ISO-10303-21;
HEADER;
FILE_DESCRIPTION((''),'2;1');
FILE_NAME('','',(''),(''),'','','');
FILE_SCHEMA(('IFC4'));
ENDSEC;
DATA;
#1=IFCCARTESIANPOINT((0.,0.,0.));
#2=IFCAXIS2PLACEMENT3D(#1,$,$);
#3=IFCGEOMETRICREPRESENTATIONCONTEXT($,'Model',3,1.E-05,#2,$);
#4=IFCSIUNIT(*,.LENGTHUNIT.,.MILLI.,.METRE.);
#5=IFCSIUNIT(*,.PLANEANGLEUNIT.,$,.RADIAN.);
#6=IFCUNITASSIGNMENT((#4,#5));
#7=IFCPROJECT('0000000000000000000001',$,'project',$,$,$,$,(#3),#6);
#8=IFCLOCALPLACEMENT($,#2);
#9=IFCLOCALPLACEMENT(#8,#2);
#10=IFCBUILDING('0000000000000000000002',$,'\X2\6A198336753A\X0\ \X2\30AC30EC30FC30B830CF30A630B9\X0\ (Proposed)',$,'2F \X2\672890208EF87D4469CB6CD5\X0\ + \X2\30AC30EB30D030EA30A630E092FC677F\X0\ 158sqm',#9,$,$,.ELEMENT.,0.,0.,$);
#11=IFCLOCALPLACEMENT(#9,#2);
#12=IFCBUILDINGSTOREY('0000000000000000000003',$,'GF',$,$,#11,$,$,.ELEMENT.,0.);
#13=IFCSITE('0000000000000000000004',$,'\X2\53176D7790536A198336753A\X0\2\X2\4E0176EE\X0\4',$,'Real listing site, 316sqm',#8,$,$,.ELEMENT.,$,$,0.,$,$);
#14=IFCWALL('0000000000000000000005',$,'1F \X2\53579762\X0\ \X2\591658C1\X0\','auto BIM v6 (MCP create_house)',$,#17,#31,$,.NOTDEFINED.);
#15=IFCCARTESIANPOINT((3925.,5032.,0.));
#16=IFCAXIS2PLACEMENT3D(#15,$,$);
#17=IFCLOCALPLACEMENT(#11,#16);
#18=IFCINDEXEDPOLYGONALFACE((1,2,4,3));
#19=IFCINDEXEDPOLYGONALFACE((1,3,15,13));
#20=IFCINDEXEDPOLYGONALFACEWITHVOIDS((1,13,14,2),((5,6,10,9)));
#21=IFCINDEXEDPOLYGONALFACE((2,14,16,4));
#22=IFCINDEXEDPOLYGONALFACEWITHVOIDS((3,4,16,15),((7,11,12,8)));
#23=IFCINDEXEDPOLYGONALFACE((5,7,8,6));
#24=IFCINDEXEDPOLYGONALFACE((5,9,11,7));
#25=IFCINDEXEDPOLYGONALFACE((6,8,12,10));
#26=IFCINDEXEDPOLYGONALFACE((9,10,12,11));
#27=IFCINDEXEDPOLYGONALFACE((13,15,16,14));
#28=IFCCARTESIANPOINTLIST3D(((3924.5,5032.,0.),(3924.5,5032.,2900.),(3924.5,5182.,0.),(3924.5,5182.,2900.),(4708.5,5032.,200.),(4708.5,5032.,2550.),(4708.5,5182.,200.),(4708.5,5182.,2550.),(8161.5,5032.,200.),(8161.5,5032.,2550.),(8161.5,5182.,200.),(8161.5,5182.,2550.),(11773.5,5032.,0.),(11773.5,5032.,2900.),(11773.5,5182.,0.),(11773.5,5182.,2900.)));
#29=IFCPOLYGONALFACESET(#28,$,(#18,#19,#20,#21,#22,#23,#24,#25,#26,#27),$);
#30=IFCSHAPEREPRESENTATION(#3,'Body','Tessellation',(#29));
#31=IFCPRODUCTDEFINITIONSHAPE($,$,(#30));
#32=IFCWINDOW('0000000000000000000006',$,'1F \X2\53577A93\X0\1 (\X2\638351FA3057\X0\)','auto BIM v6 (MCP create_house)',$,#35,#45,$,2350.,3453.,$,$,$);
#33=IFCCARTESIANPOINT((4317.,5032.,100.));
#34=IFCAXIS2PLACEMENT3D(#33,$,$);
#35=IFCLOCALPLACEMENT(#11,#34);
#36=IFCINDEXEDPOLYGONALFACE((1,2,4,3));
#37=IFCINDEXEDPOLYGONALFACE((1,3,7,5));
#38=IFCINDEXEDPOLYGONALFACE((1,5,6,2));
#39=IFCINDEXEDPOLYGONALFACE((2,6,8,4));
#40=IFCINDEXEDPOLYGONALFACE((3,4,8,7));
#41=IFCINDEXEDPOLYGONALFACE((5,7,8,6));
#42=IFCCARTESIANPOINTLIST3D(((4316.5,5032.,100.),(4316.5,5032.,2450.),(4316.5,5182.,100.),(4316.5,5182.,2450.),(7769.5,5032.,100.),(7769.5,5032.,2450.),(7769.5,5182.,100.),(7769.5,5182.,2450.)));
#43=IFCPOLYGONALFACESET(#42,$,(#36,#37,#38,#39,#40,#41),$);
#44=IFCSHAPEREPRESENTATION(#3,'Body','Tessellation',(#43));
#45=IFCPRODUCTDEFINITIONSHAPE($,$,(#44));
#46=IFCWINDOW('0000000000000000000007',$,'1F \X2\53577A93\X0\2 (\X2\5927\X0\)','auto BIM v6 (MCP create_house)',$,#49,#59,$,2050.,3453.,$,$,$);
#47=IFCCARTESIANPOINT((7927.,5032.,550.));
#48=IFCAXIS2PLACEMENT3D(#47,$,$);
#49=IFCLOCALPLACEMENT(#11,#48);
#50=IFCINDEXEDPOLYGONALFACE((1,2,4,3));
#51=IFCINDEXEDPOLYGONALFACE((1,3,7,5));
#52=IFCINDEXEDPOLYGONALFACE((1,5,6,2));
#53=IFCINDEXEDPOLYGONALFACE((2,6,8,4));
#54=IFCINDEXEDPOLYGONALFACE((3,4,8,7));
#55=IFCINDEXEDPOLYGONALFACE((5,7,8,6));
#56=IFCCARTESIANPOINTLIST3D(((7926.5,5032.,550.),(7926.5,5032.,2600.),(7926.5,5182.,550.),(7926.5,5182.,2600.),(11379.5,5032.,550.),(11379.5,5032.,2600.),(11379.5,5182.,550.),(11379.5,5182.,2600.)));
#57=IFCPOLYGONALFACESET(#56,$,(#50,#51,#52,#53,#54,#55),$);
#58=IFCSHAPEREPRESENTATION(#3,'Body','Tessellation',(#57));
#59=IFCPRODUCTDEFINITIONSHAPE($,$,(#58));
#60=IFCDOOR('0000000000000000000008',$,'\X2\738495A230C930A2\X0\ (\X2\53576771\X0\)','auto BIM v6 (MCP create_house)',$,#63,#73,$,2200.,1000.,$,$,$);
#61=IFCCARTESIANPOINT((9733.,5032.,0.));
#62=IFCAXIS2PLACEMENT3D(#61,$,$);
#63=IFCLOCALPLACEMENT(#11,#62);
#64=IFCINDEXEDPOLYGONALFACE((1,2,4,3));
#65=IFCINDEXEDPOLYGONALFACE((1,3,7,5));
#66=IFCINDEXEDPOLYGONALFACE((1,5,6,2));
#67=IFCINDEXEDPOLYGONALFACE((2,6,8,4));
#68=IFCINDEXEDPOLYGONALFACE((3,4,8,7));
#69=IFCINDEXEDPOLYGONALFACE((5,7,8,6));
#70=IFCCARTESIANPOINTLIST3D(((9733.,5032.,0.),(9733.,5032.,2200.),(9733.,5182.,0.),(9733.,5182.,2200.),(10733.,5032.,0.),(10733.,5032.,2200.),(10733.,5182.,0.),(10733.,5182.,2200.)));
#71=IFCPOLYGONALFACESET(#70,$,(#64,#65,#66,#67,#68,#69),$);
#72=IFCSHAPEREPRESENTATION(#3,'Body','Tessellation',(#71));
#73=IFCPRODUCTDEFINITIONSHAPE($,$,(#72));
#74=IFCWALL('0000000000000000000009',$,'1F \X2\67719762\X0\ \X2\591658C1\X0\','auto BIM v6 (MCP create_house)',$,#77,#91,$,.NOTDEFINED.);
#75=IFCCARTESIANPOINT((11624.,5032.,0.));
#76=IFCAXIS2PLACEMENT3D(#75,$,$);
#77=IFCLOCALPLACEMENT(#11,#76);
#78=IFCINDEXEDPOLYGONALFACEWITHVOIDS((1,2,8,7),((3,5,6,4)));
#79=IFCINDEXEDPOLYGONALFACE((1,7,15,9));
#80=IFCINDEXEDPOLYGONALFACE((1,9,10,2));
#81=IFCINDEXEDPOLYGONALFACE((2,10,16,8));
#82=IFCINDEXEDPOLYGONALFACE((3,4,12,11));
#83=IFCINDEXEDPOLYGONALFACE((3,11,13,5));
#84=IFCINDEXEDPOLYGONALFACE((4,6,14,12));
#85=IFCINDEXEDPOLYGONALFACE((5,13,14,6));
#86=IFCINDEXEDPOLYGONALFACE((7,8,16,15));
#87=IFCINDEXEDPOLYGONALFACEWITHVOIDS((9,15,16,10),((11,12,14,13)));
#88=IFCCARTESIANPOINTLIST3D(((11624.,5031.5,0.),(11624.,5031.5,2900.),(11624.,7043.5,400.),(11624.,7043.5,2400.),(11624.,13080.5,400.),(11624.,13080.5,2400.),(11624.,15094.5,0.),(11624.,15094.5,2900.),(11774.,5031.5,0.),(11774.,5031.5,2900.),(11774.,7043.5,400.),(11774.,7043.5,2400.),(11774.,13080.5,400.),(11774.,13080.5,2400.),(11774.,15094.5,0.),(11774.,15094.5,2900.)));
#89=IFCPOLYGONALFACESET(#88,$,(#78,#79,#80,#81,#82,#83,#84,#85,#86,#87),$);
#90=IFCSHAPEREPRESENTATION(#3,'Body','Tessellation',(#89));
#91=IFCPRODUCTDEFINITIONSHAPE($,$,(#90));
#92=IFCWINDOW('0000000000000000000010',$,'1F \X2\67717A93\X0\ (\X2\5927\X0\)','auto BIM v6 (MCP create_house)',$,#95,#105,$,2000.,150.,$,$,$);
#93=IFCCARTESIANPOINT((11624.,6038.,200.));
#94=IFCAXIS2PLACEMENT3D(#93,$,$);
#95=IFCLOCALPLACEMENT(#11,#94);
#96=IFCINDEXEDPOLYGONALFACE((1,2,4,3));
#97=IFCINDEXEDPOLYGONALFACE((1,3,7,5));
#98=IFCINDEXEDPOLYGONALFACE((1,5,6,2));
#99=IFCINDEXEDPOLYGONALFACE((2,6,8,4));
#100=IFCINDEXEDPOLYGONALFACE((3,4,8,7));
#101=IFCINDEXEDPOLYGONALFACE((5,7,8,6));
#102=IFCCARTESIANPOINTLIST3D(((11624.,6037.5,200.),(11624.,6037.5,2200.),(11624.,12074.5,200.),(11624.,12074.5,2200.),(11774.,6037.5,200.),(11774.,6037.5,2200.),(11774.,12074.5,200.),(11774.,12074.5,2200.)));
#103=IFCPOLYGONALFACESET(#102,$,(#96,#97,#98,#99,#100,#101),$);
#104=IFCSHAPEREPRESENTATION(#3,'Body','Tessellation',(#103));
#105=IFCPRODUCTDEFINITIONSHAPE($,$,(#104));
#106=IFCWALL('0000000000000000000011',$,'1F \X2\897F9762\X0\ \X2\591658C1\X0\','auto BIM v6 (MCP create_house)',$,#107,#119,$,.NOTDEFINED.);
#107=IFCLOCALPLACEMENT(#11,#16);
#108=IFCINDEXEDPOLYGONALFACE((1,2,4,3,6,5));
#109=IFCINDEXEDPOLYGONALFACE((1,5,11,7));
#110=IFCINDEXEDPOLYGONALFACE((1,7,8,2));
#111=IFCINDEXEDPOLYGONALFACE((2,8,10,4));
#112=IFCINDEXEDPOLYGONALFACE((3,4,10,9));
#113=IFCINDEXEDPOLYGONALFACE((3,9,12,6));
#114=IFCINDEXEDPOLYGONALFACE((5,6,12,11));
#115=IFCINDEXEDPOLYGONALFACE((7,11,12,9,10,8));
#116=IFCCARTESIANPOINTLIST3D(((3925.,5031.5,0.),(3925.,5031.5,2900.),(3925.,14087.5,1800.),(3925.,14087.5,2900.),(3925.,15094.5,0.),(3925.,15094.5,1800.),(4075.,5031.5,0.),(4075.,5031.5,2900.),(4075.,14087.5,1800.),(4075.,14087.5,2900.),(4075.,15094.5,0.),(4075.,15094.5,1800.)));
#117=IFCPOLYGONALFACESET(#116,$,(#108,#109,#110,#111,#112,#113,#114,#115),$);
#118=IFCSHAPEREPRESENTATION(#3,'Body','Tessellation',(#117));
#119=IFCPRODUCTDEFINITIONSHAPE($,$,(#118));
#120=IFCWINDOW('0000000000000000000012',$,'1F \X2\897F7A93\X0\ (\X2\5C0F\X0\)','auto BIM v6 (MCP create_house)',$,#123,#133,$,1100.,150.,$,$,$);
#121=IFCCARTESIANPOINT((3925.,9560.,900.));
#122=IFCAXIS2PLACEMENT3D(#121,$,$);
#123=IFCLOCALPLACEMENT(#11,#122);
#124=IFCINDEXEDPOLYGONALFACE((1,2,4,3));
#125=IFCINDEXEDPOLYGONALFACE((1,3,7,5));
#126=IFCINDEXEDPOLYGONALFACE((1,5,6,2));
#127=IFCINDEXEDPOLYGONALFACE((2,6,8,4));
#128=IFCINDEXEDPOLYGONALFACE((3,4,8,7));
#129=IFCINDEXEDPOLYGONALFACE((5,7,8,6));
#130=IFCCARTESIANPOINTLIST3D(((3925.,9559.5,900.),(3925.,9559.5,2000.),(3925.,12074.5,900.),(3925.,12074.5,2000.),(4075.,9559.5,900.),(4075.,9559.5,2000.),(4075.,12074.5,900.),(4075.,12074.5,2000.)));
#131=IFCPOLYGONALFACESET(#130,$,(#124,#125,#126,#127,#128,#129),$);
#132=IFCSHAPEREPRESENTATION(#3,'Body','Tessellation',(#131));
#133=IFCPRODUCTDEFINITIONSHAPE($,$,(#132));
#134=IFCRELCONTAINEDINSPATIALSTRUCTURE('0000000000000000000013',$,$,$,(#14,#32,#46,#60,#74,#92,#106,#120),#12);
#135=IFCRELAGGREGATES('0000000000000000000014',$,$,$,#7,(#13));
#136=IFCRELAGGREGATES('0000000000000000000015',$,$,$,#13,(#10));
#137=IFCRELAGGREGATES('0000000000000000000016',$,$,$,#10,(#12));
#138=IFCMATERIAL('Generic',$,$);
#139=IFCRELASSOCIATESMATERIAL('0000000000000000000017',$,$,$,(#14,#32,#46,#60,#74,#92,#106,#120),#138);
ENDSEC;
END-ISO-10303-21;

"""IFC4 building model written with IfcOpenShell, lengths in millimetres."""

from ifc_helpers import new_model, si_unit, frame, frame_2d, origin, place, context, project, spatial, rectangle, extrude, material, element, fill, save


model = new_model("IFC4")

# Units and contexts
model_context = context("Model", 3, precision=1e-05, world=origin())
ifc_project = project(units=[si_unit("LENGTHUNIT", "METRE", prefix="MILLI"), si_unit("PLANEANGLEUNIT", "RADIAN")], contexts=[model_context])

# Site, building, storey
site_placement = place(None, origin())
site = spatial("IfcSite", under=ifc_project, at=site_placement, Name="北海道標茶町2丁目4", ObjectType="Real listing site, 316sqm", CompositionType="ELEMENT", RefElevation=0.0)
building_placement = place(site_placement, origin())
building = spatial("IfcBuilding", under=site, at=building_placement, Name="標茶町 ガレージハウス (Proposed)", ObjectType="2F 木造軸組構法 + ガルバリウム鋼板 158sqm", CompositionType="ELEMENT", ElevationOfRefHeight=0.0, ElevationOfTerrain=0.0)
storey_placement = place(building_placement, origin())
storey = spatial("IfcBuildingStorey", under=building, at=storey_placement, Name="GF", CompositionType="ELEMENT", Elevation=0.0)

# Shared definitions
ifc_material = material(Name="Generic")

# Wall, openings, windows, door
wall_1_placement = place(storey_placement, frame((3925.0, 5032.0, 0.0)))
wall_1 = element("IfcWall", 1, at=wall_1_placement, inside=storey, material=ifc_material, Name="1F 南面 外壁", Description="auto BIM v6 (MCP create_house)", PredefinedType="NOTDEFINED", context=model_context, shape_type="SweptSolid", body=[
    extrude(rectangle(XDim=7849.0, YDim=150.0, at=frame_2d((3924.0, 75.0))), frame((3925.0, 5032.0, 0.0)), (0.0, 0.0, 1.0), 2900.0),
])
opening_1_placement = place(storey_placement, frame((4317.0, 5032.0, 100.0)))
opening_1 = element("IfcOpeningElement", 2, at=opening_1_placement, cuts=wall_1, PredefinedType="NOTDEFINED", context=model_context, shape_type="SweptSolid", body=[
    extrude(rectangle(XDim=3453.0, YDim=150.0, at=frame_2d((1726.0, 75.0))), frame((4317.0, 5032.0, 100.0)), (0.0, 0.0, 1.0), 2350.0),
])
opening_2_placement = place(storey_placement, frame((7927.0, 5032.0, 550.0)))
opening_2 = element("IfcOpeningElement", 3, at=opening_2_placement, cuts=wall_1, PredefinedType="NOTDEFINED", context=model_context, shape_type="SweptSolid", body=[
    extrude(rectangle(XDim=3453.0, YDim=150.0, at=frame_2d((1726.0, 75.0))), frame((7927.0, 5032.0, 550.0)), (0.0, 0.0, 1.0), 2050.0),
])
opening_3_placement = place(storey_placement, frame((9733.0, 5032.0, 0.0)))
opening_3 = element("IfcOpeningElement", 4, at=opening_3_placement, cuts=wall_1, PredefinedType="NOTDEFINED", context=model_context, shape_type="SweptSolid", body=[
    extrude(rectangle(XDim=1000.0, YDim=150.0, at=frame_2d((500.0, 75.0))), frame((9733.0, 5032.0, 0.0)), (0.0, 0.0, 1.0), 2200.0),
])
window_1_placement = place(storey_placement, frame((4317.0, 5032.0, 100.0)))
window_1 = element("IfcWindow", 5, at=window_1_placement, inside=storey, material=ifc_material, Name="1F 南窓1 (掃出し)", Description="auto BIM v6 (MCP create_house)", OverallHeight=2350.0, OverallWidth=3453.0, context=model_context, shape_type="SweptSolid", body=[
    extrude(rectangle(XDim=3453.0, YDim=150.0, at=frame_2d((1726.0, 75.0))), frame((4317.0, 5032.0, 100.0)), (0.0, 0.0, 1.0), 2350.0),
])
fill(opening_1, window_1)
window_2_placement = place(storey_placement, frame((7927.0, 5032.0, 550.0)))
window_2 = element("IfcWindow", 6, at=window_2_placement, inside=storey, material=ifc_material, Name="1F 南窓2 (大)", Description="auto BIM v6 (MCP create_house)", OverallHeight=2050.0, OverallWidth=3453.0, context=model_context, shape_type="SweptSolid", body=[
    extrude(rectangle(XDim=3453.0, YDim=150.0, at=frame_2d((1726.0, 75.0))), frame((7927.0, 5032.0, 550.0)), (0.0, 0.0, 1.0), 2050.0),
])
fill(opening_2, window_2)
door_placement = place(storey_placement, frame((9733.0, 5032.0, 0.0)))
door = element("IfcDoor", 7, at=door_placement, inside=storey, material=ifc_material, Name="玄関ドア (南東)", Description="auto BIM v6 (MCP create_house)", OverallHeight=2200.0, OverallWidth=1000.0, context=model_context, shape_type="SweptSolid", body=[
    extrude(rectangle(XDim=1000.0, YDim=150.0, at=frame_2d((500.0, 75.0))), frame((9733.0, 5032.0, 0.0)), (0.0, 0.0, 1.0), 2200.0),
])
fill(opening_3, door)

# Walls, openings, windows
wall_2_placement = place(storey_placement, frame((11624.0, 5032.0, 0.0)))
wall_2 = element("IfcWall", 8, at=wall_2_placement, inside=storey, material=ifc_material, Name="1F 東面 外壁", Description="auto BIM v6 (MCP create_house)", PredefinedType="NOTDEFINED", context=model_context, shape_type="SweptSolid", body=[
    extrude(rectangle(XDim=150.0, YDim=10063.0, at=frame_2d((75.0, 5031.0))), frame((11624.0, 5032.0, 0.0)), (0.0, 0.0, 1.0), 2900.0),
])
opening_4_placement = place(storey_placement, frame((11624.0, 6038.0, 200.0)))
opening_4 = element("IfcOpeningElement", 9, at=opening_4_placement, cuts=wall_2, PredefinedType="NOTDEFINED", context=model_context, shape_type="SweptSolid", body=[
    extrude(rectangle(XDim=150.0, YDim=6037.0, at=frame_2d((75.0, 3018.0))), frame((11624.0, 6038.0, 200.0)), (0.0, 0.0, 1.0), 2000.0),
])
window_3_placement = place(storey_placement, frame((11624.0, 6038.0, 200.0)))
window_3 = element("IfcWindow", 10, at=window_3_placement, inside=storey, material=ifc_material, Name="1F 東窓 (大)", Description="auto BIM v6 (MCP create_house)", OverallHeight=2000.0, OverallWidth=150.0, context=model_context, shape_type="SweptSolid", body=[
    extrude(rectangle(XDim=150.0, YDim=6037.0, at=frame_2d((75.0, 3018.0))), frame((11624.0, 6038.0, 200.0)), (0.0, 0.0, 1.0), 2000.0),
])
fill(opening_4, window_3)
wall_3_placement = place(storey_placement, frame((3925.0, 5032.0, 0.0)))
wall_3 = element("IfcWall", 11, at=wall_3_placement, inside=storey, material=ifc_material, Name="1F 西面 外壁", Description="auto BIM v6 (MCP create_house)", PredefinedType="NOTDEFINED", context=model_context, shape_type="SweptSolid", body=[
    extrude(rectangle(XDim=150.0, YDim=10063.0, at=frame_2d((75.0, 5031.0))), frame((3925.0, 5032.0, 0.0)), (0.0, 0.0, 1.0), 2900.0),
])
opening_5_placement = place(storey_placement, frame((3925.0, 9560.0, 900.0)))
opening_5 = element("IfcOpeningElement", 12, at=opening_5_placement, cuts=wall_3, PredefinedType="NOTDEFINED", context=model_context, shape_type="SweptSolid", body=[
    extrude(rectangle(XDim=150.0, YDim=2515.0, at=frame_2d((75.0, 1257.0))), frame((3925.0, 9560.0, 900.0)), (0.0, 0.0, 1.0), 1100.0),
])
window_4_placement = place(storey_placement, frame((3925.0, 9560.0, 900.0)))
window_4 = element("IfcWindow", 13, at=window_4_placement, inside=storey, material=ifc_material, Name="1F 西窓 (小)", Description="auto BIM v6 (MCP create_house)", OverallHeight=1100.0, OverallWidth=150.0, context=model_context, shape_type="SweptSolid", body=[
    extrude(rectangle(XDim=150.0, YDim=2515.0, at=frame_2d((75.0, 1257.0))), frame((3925.0, 9560.0, 900.0)), (0.0, 0.0, 1.0), 1100.0),
])
fill(opening_5, window_4)

save(model, "model.ifc")
